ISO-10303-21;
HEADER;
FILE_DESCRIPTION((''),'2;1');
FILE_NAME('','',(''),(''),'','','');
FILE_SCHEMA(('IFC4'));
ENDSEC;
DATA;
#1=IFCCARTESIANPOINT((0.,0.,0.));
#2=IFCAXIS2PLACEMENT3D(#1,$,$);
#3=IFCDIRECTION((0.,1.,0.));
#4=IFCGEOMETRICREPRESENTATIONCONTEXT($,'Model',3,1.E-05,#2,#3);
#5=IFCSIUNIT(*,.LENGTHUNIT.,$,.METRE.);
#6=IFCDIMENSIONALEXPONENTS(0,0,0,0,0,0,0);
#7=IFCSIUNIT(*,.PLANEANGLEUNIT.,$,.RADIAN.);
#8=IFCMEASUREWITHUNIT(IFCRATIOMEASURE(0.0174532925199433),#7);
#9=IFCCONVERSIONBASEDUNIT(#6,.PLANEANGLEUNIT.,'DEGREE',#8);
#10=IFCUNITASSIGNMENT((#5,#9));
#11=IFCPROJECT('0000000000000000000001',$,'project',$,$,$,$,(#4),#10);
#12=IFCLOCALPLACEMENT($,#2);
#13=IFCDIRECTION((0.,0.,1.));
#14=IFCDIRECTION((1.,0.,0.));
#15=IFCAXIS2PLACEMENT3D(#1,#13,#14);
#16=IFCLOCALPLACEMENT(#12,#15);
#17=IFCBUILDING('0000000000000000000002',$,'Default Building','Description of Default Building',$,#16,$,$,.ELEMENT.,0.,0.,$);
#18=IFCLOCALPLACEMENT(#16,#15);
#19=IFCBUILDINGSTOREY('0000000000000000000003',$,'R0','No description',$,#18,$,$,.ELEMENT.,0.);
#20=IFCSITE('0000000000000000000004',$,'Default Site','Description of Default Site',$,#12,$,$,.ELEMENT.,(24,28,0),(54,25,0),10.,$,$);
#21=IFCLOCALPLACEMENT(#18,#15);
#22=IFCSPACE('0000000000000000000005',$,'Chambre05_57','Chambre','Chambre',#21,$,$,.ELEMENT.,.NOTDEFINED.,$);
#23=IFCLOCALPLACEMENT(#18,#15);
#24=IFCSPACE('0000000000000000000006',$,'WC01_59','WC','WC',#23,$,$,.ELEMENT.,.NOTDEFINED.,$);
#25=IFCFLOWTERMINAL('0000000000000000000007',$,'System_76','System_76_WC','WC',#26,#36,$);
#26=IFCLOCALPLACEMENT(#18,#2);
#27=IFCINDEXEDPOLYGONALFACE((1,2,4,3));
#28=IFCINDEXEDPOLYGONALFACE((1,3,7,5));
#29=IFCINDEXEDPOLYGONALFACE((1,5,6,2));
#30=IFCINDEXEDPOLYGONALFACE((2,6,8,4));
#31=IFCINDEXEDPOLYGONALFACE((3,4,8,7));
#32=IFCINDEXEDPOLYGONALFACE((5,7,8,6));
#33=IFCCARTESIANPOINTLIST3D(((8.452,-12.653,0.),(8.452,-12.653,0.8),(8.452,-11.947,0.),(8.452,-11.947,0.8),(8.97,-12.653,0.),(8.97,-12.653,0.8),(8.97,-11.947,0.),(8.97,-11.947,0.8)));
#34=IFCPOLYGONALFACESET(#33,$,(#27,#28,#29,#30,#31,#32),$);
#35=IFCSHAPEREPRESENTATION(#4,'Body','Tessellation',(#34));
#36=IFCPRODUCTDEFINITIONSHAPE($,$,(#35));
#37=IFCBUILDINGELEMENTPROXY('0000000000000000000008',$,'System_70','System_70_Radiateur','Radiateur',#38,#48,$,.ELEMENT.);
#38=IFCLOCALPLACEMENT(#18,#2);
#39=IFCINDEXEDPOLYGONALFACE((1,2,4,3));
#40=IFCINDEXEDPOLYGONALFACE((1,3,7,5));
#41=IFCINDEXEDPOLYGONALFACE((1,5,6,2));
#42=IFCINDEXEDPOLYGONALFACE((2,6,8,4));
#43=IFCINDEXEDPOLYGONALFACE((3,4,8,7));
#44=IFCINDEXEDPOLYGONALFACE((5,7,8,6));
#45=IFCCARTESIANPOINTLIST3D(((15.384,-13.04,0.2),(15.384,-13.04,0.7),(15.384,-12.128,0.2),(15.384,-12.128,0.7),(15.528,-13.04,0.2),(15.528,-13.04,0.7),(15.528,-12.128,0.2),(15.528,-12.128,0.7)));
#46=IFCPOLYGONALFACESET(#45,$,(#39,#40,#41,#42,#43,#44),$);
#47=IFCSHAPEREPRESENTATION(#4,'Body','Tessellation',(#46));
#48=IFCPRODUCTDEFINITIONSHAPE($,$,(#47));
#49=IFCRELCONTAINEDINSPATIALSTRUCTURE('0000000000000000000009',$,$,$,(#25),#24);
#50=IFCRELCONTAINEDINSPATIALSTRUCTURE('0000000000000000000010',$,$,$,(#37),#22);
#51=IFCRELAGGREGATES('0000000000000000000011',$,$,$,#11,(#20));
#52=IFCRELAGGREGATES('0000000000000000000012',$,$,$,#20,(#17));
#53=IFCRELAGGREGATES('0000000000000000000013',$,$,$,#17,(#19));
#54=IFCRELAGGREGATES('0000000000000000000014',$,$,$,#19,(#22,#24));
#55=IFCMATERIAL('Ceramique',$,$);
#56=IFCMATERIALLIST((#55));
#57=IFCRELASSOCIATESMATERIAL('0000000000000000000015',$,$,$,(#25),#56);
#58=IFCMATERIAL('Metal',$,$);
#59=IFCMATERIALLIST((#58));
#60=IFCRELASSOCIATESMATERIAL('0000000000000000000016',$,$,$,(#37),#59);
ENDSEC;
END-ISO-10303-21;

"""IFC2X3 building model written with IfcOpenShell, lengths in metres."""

from ifc_helpers import new_model, entity, si_unit, converted_unit, direction, frame, origin, origin_with_axes, place, context, project, spatial, polyline, outline, extrude, material, material_list, element, save


model = new_model("IFC2X3")

# Units and contexts
model_context = context("Model", 3, precision=1e-05, world=origin(), true_north=direction((0.0, 1.0, 0.0)))
ifc_project = project(units=[si_unit("LENGTHUNIT", "METRE"), converted_unit("PLANEANGLEUNIT", "DEGREE", entity("IfcRatioMeasure", 0.0174532925199433), si_unit("PLANEANGLEUNIT", "RADIAN"), dimensions=[0, 0, 0, 0, 0, 0, 0])], contexts=[model_context])

# Site, building, storey
site_placement = place(None, origin())
site = spatial("IfcSite", under=ifc_project, at=site_placement, Name="Default Site", Description="Description of Default Site", CompositionType="ELEMENT", RefLatitude=(24, 28, 0), RefLongitude=(54, 25, 0), RefElevation=10.0)
building_placement = place(site_placement, origin_with_axes())
building = spatial("IfcBuilding", under=site, at=building_placement, Name="Default Building", Description="Description of Default Building", CompositionType="ELEMENT", ElevationOfRefHeight=0.0, ElevationOfTerrain=0.0)
storey_placement = place(building_placement, origin_with_axes())
storey = spatial("IfcBuildingStorey", under=building, at=storey_placement, Name="R0", Description="No description", CompositionType="ELEMENT", Elevation=0.0)

# Shared definitions
space_1_placement = place(storey_placement, origin_with_axes())
space_1 = spatial("IfcSpace", under=storey, at=space_1_placement, Name="Chambre05_57", Description="Chambre", ObjectType="Chambre", CompositionType="ELEMENT", InteriorOrExteriorSpace="NOTDEFINED")

# Shared definitions
space_2_placement = place(storey_placement, origin_with_axes())
space_2 = spatial("IfcSpace", under=storey, at=space_2_placement, Name="WC01_59", Description="WC", ObjectType="WC", CompositionType="ELEMENT", InteriorOrExteriorSpace="NOTDEFINED")

# Flow terminal
ifc_material_1 = material(Name="Ceramique")
ifc_material_list_1 = material_list([ifc_material_1])
flow_terminal_placement = place(storey_placement, frame((8.711, -12.653, 0.0), z_axis=(0.0, 0.0, 1.0), x_axis=(0.0, 0.706, 0.0)))
element("IfcFlowTerminal", 1, at=flow_terminal_placement, inside=space_2, material=ifc_material_list_1, Name="System_76", Description="System_76_WC", ObjectType="WC", context=model_context, shape_type="SweptSolid", body=[
    extrude(outline(polyline([(0.0, -0.259), (0.706, -0.259), (0.706, 0.259), (0.0, 0.259), (0.0, -0.259)])), origin(), (0.0, 0.0, 1.0), 0.8),
])

# Building element proxy
ifc_material_2 = material(Name="Metal")
ifc_material_list_2 = material_list([ifc_material_2])
proxy_placement = place(storey_placement, frame((15.456, -13.04, 0.2), z_axis=(0.0, 0.0, 1.0), x_axis=(0.0, 0.912, 0.0)))
element("IfcBuildingElementProxy", 2, at=proxy_placement, inside=space_1, material=ifc_material_list_2, Name="System_70", Description="System_70_Radiateur", ObjectType="Radiateur", CompositionType="ELEMENT", context=model_context, shape_type="SweptSolid", body=[
    extrude(outline(polyline([(0.0, -0.072), (0.912, -0.072), (0.912, 0.072), (0.0, 0.072), (0.0, -0.072)])), origin(), (0.0, 0.0, 1.0), 0.5),
])

save(model, "model.ifc")
